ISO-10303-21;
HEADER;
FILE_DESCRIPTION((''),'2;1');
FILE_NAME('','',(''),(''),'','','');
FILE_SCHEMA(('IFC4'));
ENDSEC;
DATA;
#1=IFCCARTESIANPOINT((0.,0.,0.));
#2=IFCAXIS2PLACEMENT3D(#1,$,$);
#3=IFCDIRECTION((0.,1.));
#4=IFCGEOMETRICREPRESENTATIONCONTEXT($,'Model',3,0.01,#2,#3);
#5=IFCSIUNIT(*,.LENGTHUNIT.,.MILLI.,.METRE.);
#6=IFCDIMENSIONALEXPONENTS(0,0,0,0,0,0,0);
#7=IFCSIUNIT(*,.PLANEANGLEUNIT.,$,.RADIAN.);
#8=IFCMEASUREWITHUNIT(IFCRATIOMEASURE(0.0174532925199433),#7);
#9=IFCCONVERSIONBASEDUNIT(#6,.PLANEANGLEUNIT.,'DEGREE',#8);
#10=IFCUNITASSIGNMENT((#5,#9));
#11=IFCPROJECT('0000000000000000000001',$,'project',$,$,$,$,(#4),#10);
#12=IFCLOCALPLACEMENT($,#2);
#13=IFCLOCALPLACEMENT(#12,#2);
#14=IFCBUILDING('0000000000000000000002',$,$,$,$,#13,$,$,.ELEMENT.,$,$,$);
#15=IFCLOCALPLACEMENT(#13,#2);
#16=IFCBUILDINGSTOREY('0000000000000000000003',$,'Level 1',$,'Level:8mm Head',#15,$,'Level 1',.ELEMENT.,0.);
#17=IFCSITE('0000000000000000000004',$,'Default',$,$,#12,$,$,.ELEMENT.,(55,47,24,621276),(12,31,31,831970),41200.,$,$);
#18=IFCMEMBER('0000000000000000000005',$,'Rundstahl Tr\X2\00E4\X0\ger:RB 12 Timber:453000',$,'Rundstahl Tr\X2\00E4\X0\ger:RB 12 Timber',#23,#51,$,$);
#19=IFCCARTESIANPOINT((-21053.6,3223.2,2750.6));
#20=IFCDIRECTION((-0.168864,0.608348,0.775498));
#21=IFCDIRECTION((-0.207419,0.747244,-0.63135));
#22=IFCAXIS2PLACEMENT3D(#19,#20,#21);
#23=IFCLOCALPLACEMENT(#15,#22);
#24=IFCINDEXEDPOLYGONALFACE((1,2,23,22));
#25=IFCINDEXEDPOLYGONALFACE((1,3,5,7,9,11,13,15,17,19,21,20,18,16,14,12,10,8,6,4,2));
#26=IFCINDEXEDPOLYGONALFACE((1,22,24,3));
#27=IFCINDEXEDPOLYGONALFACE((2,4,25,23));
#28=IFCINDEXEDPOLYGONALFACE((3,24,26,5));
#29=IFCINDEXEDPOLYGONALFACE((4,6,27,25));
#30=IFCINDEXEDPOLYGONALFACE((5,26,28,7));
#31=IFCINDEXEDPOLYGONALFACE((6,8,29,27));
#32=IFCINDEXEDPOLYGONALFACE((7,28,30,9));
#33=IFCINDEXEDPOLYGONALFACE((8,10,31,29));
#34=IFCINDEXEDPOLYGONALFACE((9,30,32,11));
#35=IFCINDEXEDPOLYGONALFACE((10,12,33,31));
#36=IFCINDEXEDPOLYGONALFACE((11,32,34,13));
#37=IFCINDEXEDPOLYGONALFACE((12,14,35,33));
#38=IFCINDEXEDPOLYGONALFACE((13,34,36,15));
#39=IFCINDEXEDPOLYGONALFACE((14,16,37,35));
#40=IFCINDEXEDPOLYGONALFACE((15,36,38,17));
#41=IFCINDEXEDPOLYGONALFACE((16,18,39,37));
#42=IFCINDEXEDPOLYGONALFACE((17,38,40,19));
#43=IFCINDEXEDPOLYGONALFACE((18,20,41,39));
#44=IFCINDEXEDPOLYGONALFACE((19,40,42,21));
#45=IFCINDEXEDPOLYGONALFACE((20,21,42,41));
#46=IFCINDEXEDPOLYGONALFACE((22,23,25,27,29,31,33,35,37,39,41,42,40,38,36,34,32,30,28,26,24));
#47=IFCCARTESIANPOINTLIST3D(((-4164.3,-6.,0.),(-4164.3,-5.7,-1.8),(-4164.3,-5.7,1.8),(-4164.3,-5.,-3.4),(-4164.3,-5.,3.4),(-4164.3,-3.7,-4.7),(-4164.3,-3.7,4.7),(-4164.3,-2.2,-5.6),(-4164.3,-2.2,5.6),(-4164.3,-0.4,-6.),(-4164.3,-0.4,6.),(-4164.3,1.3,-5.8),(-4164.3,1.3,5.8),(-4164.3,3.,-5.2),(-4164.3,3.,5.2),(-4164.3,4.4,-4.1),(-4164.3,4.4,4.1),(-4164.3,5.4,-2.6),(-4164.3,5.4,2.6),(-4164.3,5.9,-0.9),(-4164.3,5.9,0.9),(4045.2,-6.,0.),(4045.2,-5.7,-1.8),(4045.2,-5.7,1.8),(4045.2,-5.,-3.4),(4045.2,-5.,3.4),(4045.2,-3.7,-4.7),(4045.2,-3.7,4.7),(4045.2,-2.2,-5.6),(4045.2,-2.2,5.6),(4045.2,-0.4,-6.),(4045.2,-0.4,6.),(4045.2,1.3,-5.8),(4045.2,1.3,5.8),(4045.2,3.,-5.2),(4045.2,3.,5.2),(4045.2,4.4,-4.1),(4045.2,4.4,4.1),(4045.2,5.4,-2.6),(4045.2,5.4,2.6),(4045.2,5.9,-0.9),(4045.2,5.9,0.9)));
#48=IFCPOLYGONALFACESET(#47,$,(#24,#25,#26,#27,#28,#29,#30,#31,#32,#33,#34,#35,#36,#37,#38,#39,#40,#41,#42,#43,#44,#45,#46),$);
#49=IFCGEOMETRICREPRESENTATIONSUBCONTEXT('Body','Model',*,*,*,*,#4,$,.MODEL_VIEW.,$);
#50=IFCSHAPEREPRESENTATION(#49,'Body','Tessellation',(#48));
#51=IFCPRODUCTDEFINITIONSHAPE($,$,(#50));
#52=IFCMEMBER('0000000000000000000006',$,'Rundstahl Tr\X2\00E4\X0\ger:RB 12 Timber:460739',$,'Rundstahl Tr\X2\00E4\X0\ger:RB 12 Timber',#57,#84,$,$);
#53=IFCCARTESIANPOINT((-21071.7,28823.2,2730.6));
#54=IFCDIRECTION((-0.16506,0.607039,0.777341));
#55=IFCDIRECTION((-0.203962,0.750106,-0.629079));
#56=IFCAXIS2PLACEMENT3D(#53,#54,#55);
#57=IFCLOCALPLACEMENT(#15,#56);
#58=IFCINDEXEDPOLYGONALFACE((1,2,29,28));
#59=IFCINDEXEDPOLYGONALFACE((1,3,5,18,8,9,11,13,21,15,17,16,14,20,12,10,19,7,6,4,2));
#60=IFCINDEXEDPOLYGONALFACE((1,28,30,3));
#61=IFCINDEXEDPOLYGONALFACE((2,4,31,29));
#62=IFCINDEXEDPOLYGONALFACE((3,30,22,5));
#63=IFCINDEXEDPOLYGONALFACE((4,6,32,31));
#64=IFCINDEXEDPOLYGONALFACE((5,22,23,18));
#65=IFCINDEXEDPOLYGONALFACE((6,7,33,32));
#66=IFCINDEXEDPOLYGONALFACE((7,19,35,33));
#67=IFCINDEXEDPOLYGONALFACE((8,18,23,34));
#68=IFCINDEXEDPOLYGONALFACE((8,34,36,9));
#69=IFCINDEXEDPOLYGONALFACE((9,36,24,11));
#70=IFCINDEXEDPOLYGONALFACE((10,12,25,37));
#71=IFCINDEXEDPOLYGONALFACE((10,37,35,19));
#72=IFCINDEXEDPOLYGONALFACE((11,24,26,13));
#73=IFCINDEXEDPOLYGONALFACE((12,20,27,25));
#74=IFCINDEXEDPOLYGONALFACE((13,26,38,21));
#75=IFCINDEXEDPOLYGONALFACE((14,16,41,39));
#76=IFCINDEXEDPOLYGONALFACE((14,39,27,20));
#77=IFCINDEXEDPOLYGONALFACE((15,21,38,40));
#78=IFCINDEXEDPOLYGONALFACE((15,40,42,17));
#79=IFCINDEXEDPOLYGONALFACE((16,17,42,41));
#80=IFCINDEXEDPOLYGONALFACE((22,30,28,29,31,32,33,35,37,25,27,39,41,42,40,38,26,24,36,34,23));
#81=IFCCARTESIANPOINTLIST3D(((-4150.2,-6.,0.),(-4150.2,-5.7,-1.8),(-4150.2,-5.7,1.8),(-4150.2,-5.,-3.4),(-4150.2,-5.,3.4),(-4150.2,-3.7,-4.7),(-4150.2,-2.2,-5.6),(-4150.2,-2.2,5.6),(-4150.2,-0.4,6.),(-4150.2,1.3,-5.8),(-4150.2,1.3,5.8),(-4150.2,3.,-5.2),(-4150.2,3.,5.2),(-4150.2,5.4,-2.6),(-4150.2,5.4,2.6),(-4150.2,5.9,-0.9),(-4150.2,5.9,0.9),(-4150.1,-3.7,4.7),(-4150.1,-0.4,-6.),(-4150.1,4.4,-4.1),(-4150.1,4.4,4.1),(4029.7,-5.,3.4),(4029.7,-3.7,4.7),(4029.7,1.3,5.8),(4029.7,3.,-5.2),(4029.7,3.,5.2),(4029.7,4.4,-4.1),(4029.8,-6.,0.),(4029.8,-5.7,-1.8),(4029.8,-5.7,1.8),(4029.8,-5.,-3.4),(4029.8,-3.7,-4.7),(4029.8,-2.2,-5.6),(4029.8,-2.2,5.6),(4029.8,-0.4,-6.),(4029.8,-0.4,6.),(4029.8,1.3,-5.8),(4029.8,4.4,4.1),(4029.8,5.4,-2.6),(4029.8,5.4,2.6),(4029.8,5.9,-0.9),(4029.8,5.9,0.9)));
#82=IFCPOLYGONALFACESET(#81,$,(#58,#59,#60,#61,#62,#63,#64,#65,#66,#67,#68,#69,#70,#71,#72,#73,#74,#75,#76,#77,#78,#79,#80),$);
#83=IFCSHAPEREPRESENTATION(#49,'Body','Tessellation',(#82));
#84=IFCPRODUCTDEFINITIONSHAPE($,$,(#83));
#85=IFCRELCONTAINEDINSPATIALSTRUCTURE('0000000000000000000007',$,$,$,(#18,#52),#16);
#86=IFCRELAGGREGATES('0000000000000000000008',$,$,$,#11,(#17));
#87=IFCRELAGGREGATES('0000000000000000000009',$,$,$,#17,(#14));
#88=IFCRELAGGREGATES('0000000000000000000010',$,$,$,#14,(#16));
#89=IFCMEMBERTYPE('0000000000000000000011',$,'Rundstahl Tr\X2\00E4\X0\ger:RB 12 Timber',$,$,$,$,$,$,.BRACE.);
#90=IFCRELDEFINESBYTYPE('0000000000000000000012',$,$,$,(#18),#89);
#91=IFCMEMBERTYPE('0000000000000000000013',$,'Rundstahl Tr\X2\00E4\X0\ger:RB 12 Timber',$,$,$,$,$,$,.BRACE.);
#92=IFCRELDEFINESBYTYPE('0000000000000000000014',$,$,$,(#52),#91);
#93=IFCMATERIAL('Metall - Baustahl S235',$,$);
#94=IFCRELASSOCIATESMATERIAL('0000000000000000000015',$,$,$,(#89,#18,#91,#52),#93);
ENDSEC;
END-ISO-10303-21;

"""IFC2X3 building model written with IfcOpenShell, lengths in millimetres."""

from ifc_helpers import new_model, entity, si_unit, converted_unit, direction, frame, frame_2d, origin, place, context, subcontext, project, spatial, circle, extrude, source, transform, mapped, material, type_object, type_shapes, element, save


model = new_model("IFC2X3")

# Units and contexts
model_context = context("Model", 3, precision=0.01, world=origin(), true_north=direction((0.0, 1.0)))
body_context = subcontext(model_context, "Body", "Model", "MODEL_VIEW")
ifc_project = project(units=[si_unit("LENGTHUNIT", "METRE", prefix="MILLI"), converted_unit("PLANEANGLEUNIT", "DEGREE", entity("IfcRatioMeasure", 0.0174532925199433), si_unit("PLANEANGLEUNIT", "RADIAN"), dimensions=[0, 0, 0, 0, 0, 0, 0])], contexts=[model_context])

# Site, building, storey
site_placement = place(None, origin())
site = spatial("IfcSite", under=ifc_project, at=site_placement, Name="Default", CompositionType="ELEMENT", RefLatitude=(55, 47, 24, 621276), RefLongitude=(12, 31, 31, 831970), RefElevation=41200.0)
building_placement = place(site_placement, origin())
building = spatial("IfcBuilding", under=site, at=building_placement, CompositionType="ELEMENT")
storey_placement = place(building_placement, origin())
storey = spatial("IfcBuildingStorey", under=building, at=storey_placement, Name="Level 1", ObjectType="Level:8mm Head", LongName="Level 1", CompositionType="ELEMENT", Elevation=0.0)

# Member
ifc_material_1 = material(Name="Metall - Baustahl S235")
member_type_1 = type_object("IfcMemberType", Name="Rundstahl Träger:RB 12 Timber", PredefinedType="BRACE", material=ifc_material_1)
shared_shape_1 = source(origin(), body_context, "Body", "SweptSolid", [
    extrude(circle(Radius=6.0, at=frame_2d((0.0, 0.0), x_axis=(1.0, 0.0))), frame((-4164.3, 0.0, 0.0), z_axis=(1.0, 0.0, 0.0), x_axis=(0.0, -1.0, 0.0)), (0.0, 0.0, 1.0), 8209.5),
])
type_shapes(member_type_1, [shared_shape_1])
member_1_placement = place(storey_placement, frame((-21053.6, 3223.2, 2750.6), z_axis=(-0.168864, 0.608348, 0.775498), x_axis=(-0.207419, 0.747244, -0.63135)))
element("IfcMember", 1, at=member_1_placement, inside=storey, type_object=member_type_1, material=ifc_material_1, Name="Rundstahl Träger:RB 12 Timber:453000", ObjectType="Rundstahl Träger:RB 12 Timber", context=body_context, shape_type="MappedRepresentation", body=[
    mapped(shared_shape_1, transform((0.0, 0.0, 0.0), scale=1.0)),
])

# Member
member_type_2 = type_object("IfcMemberType", Name="Rundstahl Träger:RB 12 Timber", PredefinedType="BRACE", material=ifc_material_1)
shared_shape_2 = source(origin(), body_context, "Body", "SweptSolid", [
    extrude(circle(Radius=6.0, at=frame_2d((0.0, 0.0), x_axis=(1.0, 0.0))), frame((-4150.1, 0.0, 0.0), z_axis=(1.0, 0.0, 0.0), x_axis=(0.0, -1.0, 0.0)), (0.0, 0.0, 1.0), 8179.9),
])
type_shapes(member_type_2, [shared_shape_2])
member_2_placement = place(storey_placement, frame((-21071.7, 28823.2, 2730.6), z_axis=(-0.16506, 0.607039, 0.777341), x_axis=(-0.203962, 0.750106, -0.629079)))
element("IfcMember", 2, at=member_2_placement, inside=storey, type_object=member_type_2, material=ifc_material_1, Name="Rundstahl Träger:RB 12 Timber:460739", ObjectType="Rundstahl Träger:RB 12 Timber", context=body_context, shape_type="MappedRepresentation", body=[
    mapped(shared_shape_2, transform((0.0, 0.0, 0.0), scale=1.0)),
])

save(model, "model.ifc")
